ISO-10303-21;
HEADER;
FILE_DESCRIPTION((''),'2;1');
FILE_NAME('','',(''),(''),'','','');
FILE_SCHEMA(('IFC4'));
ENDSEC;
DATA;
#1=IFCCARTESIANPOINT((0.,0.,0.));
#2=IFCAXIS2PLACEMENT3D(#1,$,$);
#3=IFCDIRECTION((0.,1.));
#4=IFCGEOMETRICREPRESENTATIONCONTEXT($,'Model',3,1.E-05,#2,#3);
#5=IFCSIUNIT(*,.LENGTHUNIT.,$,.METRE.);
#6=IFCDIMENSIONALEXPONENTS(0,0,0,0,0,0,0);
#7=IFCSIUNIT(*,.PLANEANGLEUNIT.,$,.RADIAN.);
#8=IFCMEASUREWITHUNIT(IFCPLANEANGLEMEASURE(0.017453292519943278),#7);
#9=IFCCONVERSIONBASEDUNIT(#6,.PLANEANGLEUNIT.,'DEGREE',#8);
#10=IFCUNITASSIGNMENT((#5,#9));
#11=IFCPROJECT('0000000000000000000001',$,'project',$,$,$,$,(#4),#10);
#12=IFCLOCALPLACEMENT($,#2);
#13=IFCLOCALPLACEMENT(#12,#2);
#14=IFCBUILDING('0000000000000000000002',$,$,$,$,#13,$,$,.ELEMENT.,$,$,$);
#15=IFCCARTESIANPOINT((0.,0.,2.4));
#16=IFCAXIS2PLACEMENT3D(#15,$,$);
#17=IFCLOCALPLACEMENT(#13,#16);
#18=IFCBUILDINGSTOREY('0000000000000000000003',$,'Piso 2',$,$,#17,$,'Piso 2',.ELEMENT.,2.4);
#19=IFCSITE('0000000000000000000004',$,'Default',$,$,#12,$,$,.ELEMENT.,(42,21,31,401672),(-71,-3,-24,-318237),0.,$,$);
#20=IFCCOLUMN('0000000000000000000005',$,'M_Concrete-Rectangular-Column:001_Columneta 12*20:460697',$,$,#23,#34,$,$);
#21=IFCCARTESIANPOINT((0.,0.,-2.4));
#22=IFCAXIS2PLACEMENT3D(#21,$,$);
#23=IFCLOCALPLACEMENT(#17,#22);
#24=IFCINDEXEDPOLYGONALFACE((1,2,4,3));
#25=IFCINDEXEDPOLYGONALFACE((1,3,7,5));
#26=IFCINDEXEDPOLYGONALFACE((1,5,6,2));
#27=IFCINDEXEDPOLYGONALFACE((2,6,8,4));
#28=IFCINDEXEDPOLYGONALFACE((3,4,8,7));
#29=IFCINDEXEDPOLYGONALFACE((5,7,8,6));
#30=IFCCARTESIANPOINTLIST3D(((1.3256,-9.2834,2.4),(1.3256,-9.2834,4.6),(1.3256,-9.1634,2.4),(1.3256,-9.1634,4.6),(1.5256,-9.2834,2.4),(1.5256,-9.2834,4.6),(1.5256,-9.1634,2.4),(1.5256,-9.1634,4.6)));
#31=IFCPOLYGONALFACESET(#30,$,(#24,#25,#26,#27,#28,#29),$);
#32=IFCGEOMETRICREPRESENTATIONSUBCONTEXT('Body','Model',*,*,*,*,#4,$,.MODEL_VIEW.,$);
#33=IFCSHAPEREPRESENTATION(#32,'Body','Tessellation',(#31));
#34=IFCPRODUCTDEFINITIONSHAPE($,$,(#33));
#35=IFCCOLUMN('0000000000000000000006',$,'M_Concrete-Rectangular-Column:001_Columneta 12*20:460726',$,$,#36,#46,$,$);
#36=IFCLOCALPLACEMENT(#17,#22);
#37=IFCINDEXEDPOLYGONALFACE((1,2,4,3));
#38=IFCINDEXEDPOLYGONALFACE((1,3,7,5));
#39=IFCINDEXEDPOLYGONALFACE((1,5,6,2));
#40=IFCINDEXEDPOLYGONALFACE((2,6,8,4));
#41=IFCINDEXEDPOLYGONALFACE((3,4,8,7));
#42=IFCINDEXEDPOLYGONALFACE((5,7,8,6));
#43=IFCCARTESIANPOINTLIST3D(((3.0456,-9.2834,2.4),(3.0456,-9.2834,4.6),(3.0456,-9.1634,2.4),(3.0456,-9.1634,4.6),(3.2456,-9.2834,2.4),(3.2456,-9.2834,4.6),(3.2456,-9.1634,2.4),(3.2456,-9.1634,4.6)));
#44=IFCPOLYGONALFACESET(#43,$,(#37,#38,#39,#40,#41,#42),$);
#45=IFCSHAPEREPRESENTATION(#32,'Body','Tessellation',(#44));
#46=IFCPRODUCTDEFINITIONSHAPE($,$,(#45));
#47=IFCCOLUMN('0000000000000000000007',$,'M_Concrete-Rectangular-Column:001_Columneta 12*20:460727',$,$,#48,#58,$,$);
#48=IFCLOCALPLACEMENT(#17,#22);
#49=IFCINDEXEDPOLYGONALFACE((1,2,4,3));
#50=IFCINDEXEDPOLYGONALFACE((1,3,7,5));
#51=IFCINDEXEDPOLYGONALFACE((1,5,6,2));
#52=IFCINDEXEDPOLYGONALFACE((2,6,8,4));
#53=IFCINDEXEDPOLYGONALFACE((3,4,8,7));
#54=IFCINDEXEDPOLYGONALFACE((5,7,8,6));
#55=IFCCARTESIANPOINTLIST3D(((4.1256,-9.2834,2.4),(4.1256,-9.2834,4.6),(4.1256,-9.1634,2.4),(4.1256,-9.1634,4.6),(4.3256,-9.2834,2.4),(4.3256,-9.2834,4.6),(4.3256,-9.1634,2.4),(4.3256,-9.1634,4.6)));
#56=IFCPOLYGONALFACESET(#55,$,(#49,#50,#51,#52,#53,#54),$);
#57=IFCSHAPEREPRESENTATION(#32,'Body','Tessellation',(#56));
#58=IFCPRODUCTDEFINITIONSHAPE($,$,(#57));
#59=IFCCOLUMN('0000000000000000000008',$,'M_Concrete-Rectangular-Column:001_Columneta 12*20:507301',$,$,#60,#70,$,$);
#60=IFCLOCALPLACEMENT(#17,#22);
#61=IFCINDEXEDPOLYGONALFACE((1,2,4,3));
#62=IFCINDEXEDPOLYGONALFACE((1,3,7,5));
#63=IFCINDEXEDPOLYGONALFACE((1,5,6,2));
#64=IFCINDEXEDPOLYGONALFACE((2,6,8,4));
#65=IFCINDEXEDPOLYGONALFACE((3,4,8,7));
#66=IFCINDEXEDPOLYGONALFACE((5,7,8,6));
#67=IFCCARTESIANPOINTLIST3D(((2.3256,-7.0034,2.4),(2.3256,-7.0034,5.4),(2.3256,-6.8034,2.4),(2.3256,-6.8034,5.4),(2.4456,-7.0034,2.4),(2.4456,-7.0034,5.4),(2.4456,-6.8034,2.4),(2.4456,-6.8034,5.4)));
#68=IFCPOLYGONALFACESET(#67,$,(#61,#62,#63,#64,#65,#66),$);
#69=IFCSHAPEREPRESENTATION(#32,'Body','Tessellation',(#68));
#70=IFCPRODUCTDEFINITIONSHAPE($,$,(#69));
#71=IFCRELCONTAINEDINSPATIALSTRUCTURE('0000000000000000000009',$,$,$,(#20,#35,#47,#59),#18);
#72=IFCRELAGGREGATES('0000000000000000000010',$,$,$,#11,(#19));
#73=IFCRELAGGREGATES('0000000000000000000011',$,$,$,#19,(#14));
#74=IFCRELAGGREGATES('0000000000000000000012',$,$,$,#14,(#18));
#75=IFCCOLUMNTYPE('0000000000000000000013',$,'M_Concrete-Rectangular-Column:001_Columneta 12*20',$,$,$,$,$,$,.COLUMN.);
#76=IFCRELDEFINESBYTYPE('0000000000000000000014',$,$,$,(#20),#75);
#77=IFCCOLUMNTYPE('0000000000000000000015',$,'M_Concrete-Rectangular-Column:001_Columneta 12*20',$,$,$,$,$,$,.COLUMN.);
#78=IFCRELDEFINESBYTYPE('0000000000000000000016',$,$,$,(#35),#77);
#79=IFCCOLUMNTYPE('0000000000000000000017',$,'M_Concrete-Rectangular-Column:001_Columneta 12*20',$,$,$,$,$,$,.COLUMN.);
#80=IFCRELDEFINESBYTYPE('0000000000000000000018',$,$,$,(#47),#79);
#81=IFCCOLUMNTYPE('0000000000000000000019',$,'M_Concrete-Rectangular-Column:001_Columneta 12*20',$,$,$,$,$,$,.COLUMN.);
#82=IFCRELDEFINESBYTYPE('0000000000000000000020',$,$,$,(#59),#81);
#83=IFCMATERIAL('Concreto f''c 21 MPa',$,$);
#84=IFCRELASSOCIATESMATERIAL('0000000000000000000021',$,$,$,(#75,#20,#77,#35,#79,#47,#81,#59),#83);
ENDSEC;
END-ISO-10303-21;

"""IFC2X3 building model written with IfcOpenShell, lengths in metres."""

from ifc_helpers import new_model, entity, si_unit, converted_unit, direction, frame, frame_2d, origin, place, context, subcontext, project, spatial, rectangle, extrude, source, transform, mapped, material, type_object, type_shapes, element, save


model = new_model("IFC2X3")

# Units and contexts
model_context = context("Model", 3, precision=1e-05, world=origin(), true_north=direction((0.0, 1.0)))
body_context = subcontext(model_context, "Body", "Model", "MODEL_VIEW")
ifc_project = project(units=[si_unit("LENGTHUNIT", "METRE"), converted_unit("PLANEANGLEUNIT", "DEGREE", entity("IfcPlaneAngleMeasure", 0.017453292519943278), si_unit("PLANEANGLEUNIT", "RADIAN"), dimensions=[0, 0, 0, 0, 0, 0, 0])], contexts=[model_context])

# Site, building, storey
site_placement = place(None, origin())
site = spatial("IfcSite", under=ifc_project, at=site_placement, Name="Default", CompositionType="ELEMENT", RefLatitude=(42, 21, 31, 401672), RefLongitude=(-71, -3, -24, -318237), RefElevation=0.0)
building_placement = place(site_placement, origin())
building = spatial("IfcBuilding", under=site, at=building_placement, CompositionType="ELEMENT")
storey_placement = place(building_placement, frame((0.0, 0.0, 2.4)))
storey = spatial("IfcBuildingStorey", under=building, at=storey_placement, Name="Piso 2", LongName="Piso 2", CompositionType="ELEMENT", Elevation=2.4)

# Columns
ifc_material_1 = material(Name="Concreto f'c 21 MPa")
column_type_1 = type_object("IfcColumnType", Name="M_Concrete-Rectangular-Column:001_Columneta 12*20", PredefinedType="COLUMN", material=ifc_material_1)
shared_shape_1 = source(origin(), body_context, "Body", "SweptSolid", [
    extrude(rectangle(XDim=0.12, YDim=0.2, at=frame_2d((0.0, 0.0), x_axis=(1.0, 0.0))), frame((1.4256, -9.2234, 2.4), z_axis=(0.0, 0.0, 1.0), x_axis=(0.0, -1.0, 0.0)), (0.0, 0.0, 1.0), 2.2),
])
type_shapes(column_type_1, [shared_shape_1])
column_1_placement = place(storey_placement, frame((0.0, 0.0, -2.4)))
element("IfcColumn", 1, at=column_1_placement, inside=storey, type_object=column_type_1, material=ifc_material_1, Name="M_Concrete-Rectangular-Column:001_Columneta 12*20:460697", context=body_context, shape_type="MappedRepresentation", body=[
    mapped(shared_shape_1, transform((0.0, 0.0, 0.0), scale=1.0)),
])
column_type_2 = type_object("IfcColumnType", Name="M_Concrete-Rectangular-Column:001_Columneta 12*20", PredefinedType="COLUMN", material=ifc_material_1)
shared_shape_2 = source(origin(), body_context, "Body", "SweptSolid", [
    extrude(rectangle(XDim=0.12, YDim=0.2, at=frame_2d((0.0, 0.0), x_axis=(1.0, 0.0))), frame((3.1456, -9.2234, 2.4), z_axis=(0.0, 0.0, 1.0), x_axis=(0.0, -1.0, 0.0)), (0.0, 0.0, 1.0), 2.2),
])
type_shapes(column_type_2, [shared_shape_2])
column_2_placement = place(storey_placement, frame((0.0, 0.0, -2.4)))
element("IfcColumn", 2, at=column_2_placement, inside=storey, type_object=column_type_2, material=ifc_material_1, Name="M_Concrete-Rectangular-Column:001_Columneta 12*20:460726", context=body_context, shape_type="MappedRepresentation", body=[
    mapped(shared_shape_2, transform((0.0, 0.0, 0.0), scale=1.0)),
])
column_type_3 = type_object("IfcColumnType", Name="M_Concrete-Rectangular-Column:001_Columneta 12*20", PredefinedType="COLUMN", material=ifc_material_1)
shared_shape_3 = source(origin(), body_context, "Body", "SweptSolid", [
    extrude(rectangle(XDim=0.12, YDim=0.2, at=frame_2d((0.0, 0.0), x_axis=(1.0, 0.0))), frame((4.2256, -9.2234, 2.4), z_axis=(0.0, 0.0, 1.0), x_axis=(0.0, -1.0, 0.0)), (0.0, 0.0, 1.0), 2.2),
])
type_shapes(column_type_3, [shared_shape_3])
column_3_placement = place(storey_placement, frame((0.0, 0.0, -2.4)))
element("IfcColumn", 3, at=column_3_placement, inside=storey, type_object=column_type_3, material=ifc_material_1, Name="M_Concrete-Rectangular-Column:001_Columneta 12*20:460727", context=body_context, shape_type="MappedRepresentation", body=[
    mapped(shared_shape_3, transform((0.0, 0.0, 0.0), scale=1.0)),
])
column_type_4 = type_object("IfcColumnType", Name="M_Concrete-Rectangular-Column:001_Columneta 12*20", PredefinedType="COLUMN", material=ifc_material_1)
shared_shape_4 = source(origin(), body_context, "Body", "SweptSolid", [
    extrude(rectangle(XDim=0.12, YDim=0.2, at=frame_2d((0.0, 0.0), x_axis=(1.0, 0.0))), frame((2.3856, -6.9034, 2.4)), (0.0, 0.0, 1.0), 3.0),
])
type_shapes(column_type_4, [shared_shape_4])
column_4_placement = place(storey_placement, frame((0.0, 0.0, -2.4)))
element("IfcColumn", 4, at=column_4_placement, inside=storey, type_object=column_type_4, material=ifc_material_1, Name="M_Concrete-Rectangular-Column:001_Columneta 12*20:507301", context=body_context, shape_type="MappedRepresentation", body=[
    mapped(shared_shape_4, transform((0.0, 0.0, 0.0), scale=1.0)),
])

save(model, "model.ifc")
